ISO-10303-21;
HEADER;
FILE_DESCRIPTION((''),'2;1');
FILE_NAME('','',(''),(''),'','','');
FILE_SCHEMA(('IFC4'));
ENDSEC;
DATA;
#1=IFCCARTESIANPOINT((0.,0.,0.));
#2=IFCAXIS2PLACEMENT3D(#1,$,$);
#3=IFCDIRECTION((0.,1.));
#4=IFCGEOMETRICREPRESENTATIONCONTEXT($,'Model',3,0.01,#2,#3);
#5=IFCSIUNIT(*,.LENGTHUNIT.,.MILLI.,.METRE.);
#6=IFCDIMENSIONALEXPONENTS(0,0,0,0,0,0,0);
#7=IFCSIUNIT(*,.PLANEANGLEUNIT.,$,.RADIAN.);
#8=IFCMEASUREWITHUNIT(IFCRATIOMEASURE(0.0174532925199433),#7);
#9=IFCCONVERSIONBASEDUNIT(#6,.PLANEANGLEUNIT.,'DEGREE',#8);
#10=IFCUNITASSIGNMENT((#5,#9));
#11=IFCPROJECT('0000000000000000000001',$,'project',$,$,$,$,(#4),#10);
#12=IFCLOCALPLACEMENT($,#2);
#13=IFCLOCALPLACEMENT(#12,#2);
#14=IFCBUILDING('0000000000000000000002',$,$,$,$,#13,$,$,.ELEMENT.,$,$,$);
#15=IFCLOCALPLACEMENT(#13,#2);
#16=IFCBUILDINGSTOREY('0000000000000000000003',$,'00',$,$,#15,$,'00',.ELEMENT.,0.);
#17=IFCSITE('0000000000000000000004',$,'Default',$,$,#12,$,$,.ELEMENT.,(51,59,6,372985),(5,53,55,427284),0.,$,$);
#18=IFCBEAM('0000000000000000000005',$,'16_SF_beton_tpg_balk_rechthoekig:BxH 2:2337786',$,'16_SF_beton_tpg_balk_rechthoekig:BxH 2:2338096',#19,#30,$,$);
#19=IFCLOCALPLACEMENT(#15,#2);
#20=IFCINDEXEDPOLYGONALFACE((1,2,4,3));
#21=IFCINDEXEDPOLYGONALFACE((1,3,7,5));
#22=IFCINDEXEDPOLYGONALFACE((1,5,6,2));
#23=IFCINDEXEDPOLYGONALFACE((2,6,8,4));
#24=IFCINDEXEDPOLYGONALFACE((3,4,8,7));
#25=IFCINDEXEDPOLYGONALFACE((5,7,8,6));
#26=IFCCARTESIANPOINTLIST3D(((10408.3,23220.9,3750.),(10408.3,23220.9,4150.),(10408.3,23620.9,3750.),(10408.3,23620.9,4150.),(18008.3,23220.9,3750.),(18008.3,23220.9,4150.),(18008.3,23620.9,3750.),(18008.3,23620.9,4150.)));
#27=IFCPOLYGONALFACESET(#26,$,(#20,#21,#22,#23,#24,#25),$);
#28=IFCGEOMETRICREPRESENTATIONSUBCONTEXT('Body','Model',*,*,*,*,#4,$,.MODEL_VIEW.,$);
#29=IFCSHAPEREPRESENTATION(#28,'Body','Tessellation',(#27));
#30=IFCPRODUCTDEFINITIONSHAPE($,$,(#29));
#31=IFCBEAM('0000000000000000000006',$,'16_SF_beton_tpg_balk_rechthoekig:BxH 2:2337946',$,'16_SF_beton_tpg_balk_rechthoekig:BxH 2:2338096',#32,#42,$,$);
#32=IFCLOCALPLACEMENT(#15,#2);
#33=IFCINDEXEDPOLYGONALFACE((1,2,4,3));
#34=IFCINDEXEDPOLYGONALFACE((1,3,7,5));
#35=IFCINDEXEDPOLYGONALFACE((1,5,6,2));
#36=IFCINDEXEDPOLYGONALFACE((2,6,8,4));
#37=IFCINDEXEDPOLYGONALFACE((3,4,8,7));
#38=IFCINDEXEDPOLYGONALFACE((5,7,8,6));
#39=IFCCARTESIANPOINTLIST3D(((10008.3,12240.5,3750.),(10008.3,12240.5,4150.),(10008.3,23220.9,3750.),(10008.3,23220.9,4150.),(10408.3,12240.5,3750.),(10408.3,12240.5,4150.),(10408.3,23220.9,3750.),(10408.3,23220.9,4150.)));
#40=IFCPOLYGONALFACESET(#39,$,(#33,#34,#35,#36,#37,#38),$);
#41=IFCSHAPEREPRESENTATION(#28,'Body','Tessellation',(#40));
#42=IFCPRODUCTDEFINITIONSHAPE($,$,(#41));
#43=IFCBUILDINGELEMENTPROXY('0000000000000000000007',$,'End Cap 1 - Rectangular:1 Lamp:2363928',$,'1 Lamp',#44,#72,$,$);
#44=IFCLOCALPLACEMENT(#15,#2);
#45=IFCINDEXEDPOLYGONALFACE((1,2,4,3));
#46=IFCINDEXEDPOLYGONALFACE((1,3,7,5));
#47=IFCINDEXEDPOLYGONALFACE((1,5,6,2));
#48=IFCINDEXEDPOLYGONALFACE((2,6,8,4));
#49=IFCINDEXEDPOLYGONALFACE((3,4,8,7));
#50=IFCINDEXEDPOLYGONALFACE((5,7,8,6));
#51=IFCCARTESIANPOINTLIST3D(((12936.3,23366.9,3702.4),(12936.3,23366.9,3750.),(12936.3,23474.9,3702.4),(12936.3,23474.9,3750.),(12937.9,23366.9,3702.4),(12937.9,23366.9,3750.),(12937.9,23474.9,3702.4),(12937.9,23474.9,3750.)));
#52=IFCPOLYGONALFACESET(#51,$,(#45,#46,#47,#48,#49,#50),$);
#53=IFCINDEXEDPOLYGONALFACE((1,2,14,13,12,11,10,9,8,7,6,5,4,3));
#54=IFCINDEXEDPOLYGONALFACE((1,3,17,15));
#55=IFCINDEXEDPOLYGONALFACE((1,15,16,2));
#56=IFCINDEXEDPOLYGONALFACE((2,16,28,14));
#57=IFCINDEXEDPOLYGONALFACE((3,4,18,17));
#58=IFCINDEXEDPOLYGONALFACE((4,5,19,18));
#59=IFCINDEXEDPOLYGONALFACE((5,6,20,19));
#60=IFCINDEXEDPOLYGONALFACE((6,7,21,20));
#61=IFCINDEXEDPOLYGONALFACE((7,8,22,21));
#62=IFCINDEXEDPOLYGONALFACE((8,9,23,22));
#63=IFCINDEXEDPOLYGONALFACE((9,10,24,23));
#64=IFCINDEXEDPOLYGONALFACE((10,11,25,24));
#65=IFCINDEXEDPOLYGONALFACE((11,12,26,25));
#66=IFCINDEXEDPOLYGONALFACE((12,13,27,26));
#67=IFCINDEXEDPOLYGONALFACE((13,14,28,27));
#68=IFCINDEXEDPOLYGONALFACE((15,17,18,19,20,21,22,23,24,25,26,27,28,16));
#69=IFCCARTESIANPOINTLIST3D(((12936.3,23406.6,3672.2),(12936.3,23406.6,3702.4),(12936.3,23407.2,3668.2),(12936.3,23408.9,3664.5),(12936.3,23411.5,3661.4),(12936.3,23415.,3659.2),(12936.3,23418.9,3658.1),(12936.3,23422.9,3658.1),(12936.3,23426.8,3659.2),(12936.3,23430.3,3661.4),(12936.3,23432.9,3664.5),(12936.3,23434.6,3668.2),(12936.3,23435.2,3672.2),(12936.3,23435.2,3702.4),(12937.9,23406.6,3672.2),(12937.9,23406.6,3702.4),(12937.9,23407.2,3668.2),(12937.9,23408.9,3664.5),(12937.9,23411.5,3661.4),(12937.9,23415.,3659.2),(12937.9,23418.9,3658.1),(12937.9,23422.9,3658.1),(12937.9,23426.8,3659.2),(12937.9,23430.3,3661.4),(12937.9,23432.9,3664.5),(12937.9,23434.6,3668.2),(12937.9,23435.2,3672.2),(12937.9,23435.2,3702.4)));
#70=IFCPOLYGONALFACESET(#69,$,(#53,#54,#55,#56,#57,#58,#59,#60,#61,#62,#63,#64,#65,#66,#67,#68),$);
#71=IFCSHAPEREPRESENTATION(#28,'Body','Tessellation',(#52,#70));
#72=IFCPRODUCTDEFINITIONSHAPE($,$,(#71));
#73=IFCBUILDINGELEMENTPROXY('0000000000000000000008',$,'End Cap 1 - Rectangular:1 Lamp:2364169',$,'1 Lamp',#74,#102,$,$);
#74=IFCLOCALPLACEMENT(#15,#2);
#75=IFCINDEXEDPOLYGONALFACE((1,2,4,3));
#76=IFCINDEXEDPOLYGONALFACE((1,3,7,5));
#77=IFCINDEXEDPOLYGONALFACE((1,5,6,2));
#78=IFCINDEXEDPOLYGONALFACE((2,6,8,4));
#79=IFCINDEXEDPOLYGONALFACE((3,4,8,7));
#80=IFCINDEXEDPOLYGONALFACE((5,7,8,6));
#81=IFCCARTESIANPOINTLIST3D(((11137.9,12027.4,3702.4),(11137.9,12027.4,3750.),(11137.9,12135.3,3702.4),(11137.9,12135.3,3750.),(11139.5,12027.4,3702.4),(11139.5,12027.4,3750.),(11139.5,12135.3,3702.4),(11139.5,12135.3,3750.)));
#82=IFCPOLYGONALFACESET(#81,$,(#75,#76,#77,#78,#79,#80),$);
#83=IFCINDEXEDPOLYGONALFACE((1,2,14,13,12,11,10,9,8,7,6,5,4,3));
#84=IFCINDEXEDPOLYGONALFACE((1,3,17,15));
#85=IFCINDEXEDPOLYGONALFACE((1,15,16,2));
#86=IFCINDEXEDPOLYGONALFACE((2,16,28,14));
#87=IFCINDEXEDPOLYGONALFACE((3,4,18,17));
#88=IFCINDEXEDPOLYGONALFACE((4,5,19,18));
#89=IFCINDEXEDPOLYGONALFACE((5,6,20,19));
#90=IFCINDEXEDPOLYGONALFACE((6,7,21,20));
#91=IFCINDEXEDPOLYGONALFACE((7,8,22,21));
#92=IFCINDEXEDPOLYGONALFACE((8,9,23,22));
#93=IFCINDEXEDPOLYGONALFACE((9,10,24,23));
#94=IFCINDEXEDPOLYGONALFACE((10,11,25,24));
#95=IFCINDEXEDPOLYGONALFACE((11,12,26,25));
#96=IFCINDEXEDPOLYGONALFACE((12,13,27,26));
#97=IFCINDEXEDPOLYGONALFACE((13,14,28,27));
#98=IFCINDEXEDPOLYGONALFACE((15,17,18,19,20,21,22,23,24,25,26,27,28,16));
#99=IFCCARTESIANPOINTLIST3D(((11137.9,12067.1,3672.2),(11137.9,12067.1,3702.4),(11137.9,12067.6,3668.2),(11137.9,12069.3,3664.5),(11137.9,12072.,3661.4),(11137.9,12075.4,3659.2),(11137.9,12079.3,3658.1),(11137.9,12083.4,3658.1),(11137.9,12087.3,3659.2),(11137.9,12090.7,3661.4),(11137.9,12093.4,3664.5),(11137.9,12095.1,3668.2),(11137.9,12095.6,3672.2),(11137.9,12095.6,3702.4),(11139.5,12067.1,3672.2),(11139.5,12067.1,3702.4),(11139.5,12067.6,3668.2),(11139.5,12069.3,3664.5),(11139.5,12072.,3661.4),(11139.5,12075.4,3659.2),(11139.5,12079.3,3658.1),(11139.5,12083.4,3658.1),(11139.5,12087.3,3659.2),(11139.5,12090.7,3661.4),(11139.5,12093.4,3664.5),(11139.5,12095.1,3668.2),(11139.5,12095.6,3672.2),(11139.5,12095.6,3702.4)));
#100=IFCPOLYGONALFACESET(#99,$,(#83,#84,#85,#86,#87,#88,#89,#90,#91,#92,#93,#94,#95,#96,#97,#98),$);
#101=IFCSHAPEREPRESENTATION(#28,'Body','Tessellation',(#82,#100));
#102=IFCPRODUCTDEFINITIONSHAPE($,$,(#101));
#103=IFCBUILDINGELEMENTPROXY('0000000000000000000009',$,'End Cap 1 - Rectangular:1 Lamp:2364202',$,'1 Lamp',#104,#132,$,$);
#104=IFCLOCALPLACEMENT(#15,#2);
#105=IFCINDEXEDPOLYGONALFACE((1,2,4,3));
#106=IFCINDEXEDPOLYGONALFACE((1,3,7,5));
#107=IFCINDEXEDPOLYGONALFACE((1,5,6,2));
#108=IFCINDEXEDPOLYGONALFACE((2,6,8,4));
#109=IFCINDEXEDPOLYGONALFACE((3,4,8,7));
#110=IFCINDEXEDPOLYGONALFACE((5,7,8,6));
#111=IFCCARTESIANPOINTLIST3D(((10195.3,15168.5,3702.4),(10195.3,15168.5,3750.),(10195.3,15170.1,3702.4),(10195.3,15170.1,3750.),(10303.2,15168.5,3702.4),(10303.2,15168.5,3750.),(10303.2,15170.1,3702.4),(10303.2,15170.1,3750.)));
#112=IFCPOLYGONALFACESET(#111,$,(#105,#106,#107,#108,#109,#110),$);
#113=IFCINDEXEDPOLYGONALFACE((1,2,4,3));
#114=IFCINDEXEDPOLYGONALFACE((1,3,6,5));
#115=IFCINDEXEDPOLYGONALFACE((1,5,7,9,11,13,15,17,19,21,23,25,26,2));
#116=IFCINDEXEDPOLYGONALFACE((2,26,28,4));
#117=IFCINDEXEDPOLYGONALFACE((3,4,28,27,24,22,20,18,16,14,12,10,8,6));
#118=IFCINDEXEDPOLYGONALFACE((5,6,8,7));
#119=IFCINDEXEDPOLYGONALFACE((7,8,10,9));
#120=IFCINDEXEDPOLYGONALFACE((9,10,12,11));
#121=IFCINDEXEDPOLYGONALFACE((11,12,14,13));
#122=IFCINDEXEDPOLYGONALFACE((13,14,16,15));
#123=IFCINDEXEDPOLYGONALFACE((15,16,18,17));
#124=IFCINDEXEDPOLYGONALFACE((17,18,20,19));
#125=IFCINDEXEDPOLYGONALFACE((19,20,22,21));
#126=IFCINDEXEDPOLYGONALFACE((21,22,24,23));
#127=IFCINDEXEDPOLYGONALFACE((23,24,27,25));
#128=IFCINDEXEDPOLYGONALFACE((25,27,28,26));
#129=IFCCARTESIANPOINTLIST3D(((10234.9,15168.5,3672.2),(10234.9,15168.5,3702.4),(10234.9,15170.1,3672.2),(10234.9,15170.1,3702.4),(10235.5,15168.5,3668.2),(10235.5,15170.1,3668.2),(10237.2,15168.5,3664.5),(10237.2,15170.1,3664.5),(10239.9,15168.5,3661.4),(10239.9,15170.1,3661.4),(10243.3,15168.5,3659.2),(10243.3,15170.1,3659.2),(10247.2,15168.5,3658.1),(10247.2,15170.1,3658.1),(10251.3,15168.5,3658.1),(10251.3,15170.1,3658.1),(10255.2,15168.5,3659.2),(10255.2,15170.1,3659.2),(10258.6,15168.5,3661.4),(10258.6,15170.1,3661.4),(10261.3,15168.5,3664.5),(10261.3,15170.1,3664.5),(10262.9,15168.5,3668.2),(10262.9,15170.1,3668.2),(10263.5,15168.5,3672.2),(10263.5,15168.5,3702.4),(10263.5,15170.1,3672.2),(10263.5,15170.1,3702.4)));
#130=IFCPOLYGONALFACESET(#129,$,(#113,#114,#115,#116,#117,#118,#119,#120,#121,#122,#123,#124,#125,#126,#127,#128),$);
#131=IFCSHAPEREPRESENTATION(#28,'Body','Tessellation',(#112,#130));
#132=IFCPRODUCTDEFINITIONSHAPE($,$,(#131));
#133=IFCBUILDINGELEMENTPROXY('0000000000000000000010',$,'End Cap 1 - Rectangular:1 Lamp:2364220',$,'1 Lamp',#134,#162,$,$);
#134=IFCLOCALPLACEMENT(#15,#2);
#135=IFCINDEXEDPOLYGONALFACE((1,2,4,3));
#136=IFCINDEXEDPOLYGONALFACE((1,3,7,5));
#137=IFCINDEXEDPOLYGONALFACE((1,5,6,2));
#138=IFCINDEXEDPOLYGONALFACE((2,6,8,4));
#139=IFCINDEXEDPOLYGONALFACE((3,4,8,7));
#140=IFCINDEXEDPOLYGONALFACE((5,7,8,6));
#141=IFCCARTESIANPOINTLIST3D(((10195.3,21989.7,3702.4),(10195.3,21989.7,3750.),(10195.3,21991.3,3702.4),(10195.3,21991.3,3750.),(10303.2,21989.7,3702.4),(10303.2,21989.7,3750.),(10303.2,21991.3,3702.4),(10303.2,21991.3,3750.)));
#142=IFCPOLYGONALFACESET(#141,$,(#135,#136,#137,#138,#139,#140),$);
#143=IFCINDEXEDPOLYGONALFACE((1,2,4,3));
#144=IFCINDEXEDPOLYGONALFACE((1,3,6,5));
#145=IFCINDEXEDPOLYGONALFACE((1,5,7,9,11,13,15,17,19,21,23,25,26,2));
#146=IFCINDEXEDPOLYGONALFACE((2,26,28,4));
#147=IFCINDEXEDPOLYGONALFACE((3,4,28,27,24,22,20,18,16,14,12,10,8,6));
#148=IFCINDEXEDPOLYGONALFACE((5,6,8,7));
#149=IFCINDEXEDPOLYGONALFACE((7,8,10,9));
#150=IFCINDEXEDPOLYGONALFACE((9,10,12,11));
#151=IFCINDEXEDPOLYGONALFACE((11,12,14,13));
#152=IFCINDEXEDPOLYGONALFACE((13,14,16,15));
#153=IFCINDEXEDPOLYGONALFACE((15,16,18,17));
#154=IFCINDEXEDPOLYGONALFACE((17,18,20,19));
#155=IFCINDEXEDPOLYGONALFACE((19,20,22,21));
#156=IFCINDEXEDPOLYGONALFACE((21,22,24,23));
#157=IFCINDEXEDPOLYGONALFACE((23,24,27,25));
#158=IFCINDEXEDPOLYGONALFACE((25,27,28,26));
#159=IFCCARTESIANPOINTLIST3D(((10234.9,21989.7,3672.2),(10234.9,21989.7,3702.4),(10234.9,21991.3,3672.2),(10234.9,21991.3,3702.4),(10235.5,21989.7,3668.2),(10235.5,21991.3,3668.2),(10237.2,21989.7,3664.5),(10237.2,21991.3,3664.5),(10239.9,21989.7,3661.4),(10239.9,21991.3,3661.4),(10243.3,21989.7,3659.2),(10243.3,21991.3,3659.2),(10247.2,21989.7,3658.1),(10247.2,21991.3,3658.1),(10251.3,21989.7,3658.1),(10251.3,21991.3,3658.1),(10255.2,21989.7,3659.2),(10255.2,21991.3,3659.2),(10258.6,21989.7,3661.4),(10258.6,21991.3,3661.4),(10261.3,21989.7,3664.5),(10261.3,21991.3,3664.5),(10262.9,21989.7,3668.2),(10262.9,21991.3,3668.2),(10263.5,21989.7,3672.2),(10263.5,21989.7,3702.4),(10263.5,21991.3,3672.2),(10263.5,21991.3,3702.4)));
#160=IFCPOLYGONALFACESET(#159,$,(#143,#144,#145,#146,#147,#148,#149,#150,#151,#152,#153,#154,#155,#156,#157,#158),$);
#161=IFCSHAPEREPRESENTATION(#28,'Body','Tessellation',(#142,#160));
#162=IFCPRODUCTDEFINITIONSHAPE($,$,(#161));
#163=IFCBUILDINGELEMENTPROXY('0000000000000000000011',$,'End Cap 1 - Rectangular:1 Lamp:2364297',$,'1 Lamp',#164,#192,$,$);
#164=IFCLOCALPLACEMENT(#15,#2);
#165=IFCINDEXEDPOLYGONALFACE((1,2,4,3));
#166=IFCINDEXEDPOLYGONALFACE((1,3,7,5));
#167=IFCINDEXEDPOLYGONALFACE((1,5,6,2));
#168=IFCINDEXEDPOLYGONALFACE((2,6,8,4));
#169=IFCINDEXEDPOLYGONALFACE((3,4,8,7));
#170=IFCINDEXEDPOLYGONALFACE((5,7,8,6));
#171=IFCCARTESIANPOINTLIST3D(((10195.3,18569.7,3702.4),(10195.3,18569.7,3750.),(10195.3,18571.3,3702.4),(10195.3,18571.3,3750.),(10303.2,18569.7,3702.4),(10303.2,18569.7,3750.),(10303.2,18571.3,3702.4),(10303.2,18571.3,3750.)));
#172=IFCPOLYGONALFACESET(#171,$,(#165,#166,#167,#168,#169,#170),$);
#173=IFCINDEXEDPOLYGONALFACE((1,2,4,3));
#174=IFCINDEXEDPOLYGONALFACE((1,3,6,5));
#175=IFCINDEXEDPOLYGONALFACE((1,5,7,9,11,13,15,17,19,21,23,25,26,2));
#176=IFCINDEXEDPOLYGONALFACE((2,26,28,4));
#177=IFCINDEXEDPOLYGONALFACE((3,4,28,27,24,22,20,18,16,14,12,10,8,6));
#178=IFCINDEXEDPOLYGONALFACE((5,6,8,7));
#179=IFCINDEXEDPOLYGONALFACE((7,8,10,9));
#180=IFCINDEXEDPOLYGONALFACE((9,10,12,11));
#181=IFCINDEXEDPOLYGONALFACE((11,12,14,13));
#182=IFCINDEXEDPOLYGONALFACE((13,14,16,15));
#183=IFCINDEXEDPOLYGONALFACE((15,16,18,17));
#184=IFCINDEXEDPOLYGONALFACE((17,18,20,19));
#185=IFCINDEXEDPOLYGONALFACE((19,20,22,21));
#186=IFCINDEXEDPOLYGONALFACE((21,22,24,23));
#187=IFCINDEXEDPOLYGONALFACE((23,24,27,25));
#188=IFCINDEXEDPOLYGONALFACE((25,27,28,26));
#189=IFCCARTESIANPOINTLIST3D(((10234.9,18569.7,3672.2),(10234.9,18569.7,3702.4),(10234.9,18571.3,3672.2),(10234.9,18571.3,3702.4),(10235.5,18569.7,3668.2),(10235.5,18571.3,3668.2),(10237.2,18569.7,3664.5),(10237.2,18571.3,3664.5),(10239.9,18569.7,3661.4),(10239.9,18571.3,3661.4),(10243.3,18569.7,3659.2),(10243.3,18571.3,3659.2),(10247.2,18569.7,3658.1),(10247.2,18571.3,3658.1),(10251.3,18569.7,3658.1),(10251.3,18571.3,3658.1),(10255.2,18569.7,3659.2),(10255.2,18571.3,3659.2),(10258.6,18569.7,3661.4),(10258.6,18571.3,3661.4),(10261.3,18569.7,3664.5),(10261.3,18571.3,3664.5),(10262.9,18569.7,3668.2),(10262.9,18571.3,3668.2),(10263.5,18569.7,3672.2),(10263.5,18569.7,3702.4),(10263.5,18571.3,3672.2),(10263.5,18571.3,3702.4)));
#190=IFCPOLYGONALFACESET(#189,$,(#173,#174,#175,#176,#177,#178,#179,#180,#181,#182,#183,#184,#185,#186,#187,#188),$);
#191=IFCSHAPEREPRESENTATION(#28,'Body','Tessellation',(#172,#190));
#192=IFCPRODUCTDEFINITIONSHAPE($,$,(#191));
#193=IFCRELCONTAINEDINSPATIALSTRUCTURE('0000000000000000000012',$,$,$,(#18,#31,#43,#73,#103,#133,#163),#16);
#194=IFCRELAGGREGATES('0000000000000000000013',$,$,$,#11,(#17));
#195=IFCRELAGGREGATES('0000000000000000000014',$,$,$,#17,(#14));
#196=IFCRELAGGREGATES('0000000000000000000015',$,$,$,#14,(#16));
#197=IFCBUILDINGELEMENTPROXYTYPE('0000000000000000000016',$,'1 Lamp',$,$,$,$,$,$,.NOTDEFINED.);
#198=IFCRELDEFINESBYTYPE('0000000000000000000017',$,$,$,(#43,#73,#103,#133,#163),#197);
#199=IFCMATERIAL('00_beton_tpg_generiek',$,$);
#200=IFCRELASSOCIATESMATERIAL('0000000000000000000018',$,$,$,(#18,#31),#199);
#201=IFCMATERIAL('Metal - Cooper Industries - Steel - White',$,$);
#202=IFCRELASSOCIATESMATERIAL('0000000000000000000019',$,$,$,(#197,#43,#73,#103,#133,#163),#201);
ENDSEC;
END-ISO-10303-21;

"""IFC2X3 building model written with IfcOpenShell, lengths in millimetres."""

from ifc_helpers import new_model, entity, si_unit, converted_unit, direction, frame, frame_2d, origin, origin_2d_with_axis, place, context, subcontext, project, spatial, polyline, circle_curve, parameter, trimmed, segment, composite_curve, rectangle, outline, extrude, source, transform, mapped, material, type_object, type_shapes, element, save


model = new_model("IFC2X3")

# Units and contexts
model_context = context("Model", 3, precision=0.01, world=origin(), true_north=direction((0.0, 1.0)))
body_context = subcontext(model_context, "Body", "Model", "MODEL_VIEW")
ifc_project = project(units=[si_unit("LENGTHUNIT", "METRE", prefix="MILLI"), converted_unit("PLANEANGLEUNIT", "DEGREE", entity("IfcRatioMeasure", 0.0174532925199433), si_unit("PLANEANGLEUNIT", "RADIAN"), dimensions=[0, 0, 0, 0, 0, 0, 0])], contexts=[model_context])

# Site, building, storey
site_placement = place(None, origin())
site = spatial("IfcSite", under=ifc_project, at=site_placement, Name="Default", CompositionType="ELEMENT", RefLatitude=(51, 59, 6, 372985), RefLongitude=(5, 53, 55, 427284), RefElevation=0.0)
building_placement = place(site_placement, origin())
building = spatial("IfcBuilding", under=site, at=building_placement, CompositionType="ELEMENT")
storey_placement = place(building_placement, origin())
storey = spatial("IfcBuildingStorey", under=building, at=storey_placement, Name="00", LongName="00", CompositionType="ELEMENT", Elevation=0.0)

# Beams
ifc_material_1 = material(Name="00_beton_tpg_generiek")
beam_1_placement = place(storey_placement, frame((10408.3, 23420.9, 4150.0)))
element("IfcBeam", 1, at=beam_1_placement, inside=storey, material=ifc_material_1, Name="16_SF_beton_tpg_balk_rechthoekig:BxH 2:2337786", ObjectType="16_SF_beton_tpg_balk_rechthoekig:BxH 2:2338096", context=body_context, shape_type="SweptSolid", body=[
    extrude(rectangle(XDim=400.0, YDim=400.0, at=frame_2d((0.0, 0.0), x_axis=(1.0, 0.0))), frame((0.0, 0.0, -200.0), z_axis=(1.0, 0.0, 0.0), x_axis=(0.0, 0.0, -1.0)), (0.0, 0.0, 1.0), 7600.0),
])
beam_2_placement = place(storey_placement, frame((10208.3, 23220.9, 4150.0), z_axis=(0.0, 0.0, 1.0), x_axis=(0.0, -1.0, 0.0)))
element("IfcBeam", 2, at=beam_2_placement, inside=storey, material=ifc_material_1, Name="16_SF_beton_tpg_balk_rechthoekig:BxH 2:2337946", ObjectType="16_SF_beton_tpg_balk_rechthoekig:BxH 2:2338096", context=body_context, shape_type="SweptSolid", body=[
    extrude(rectangle(XDim=400.0, YDim=400.0, at=frame_2d((0.0, 0.0), x_axis=(1.0, 0.0))), frame((0.0, 0.0, -200.0), z_axis=(1.0, 0.0, 0.0), x_axis=(0.0, 0.0, -1.0)), (0.0, 0.0, 1.0), 10980.5),
])

# Building element proxies
ifc_material_2 = material(Name="Metal - Cooper Industries - Steel - White")
building_element_proxy_type_1 = type_object("IfcBuildingElementProxyType", Name="1 Lamp", PredefinedType="NOTDEFINED", material=ifc_material_2)
shared_shape_1 = source(origin(), body_context, "Body", "SweptSolid", [
    extrude(rectangle(XDim=1.6, YDim=108.0, at=origin_2d_with_axis()), frame((0.0, 0.0, 0.0), z_axis=(0.0, 0.0, 1.0), x_axis=(0.0, 1.0, 0.0)), (0.0, 0.0, 1.0), 47.6),
    extrude(outline(composite_curve([segment(polyline([(-15.1, -14.3), (15.1, -14.3)]), True, "CONTINUOUS"), segment(polyline([(15.1, -14.3), (15.1, 14.3)]), True, "CONTINUOUS"), segment(polyline([(15.1, 14.3), (-15.1, 14.3)]), True, "CONTINUOUS"), segment(trimmed(circle_curve(frame_2d((-15.1, 0.0), x_axis=(0.0, -1.0)), 14.3), [parameter(180.0)], [parameter(0.0)], True, "PARAMETER"), True, "CONTINUOUS")], self_intersect=False)), frame((0.0, -0.8, 62.7), z_axis=(0.0, 1.0, 0.0), x_axis=(0.0, 0.0, -1.0)), (0.0, 0.0, 1.0), 1.6),
])
type_shapes(building_element_proxy_type_1, [shared_shape_1])
for number, where, z_axis, x_axis, name in (
    (3, (12937.1, 23420.9, 3750.0), (0.0, 0.0, -1.0), (0.0, -1.0, 0.0), "End Cap 1 - Rectangular:1 Lamp:2363928"),
    (4, (11138.7, 12081.4, 3750.0), (0.0, 0.0, -1.0), (0.0, 1.0, 0.0), "End Cap 1 - Rectangular:1 Lamp:2364169"),
    (5, (10249.2, 15169.3, 3750.0), (0.0, 0.0, -1.0), (1.0, 0.0, 0.0), "End Cap 1 - Rectangular:1 Lamp:2364202"),
    (6, (10249.2, 21990.5, 3750.0), (0.0, 0.0, -1.0), (1.0, 0.0, 0.0), "End Cap 1 - Rectangular:1 Lamp:2364220"),
    (7, (10249.2, 18570.5, 3750.0), (0.0, 0.0, -1.0), (1.0, 0.0, 0.0), "End Cap 1 - Rectangular:1 Lamp:2364297"),
):
    element("IfcBuildingElementProxy", number, at=place(storey_placement, frame(where, z_axis=z_axis, x_axis=x_axis)), inside=storey, type_object=building_element_proxy_type_1, material=ifc_material_2, Name=name, ObjectType="1 Lamp", context=body_context, shape_type="MappedRepresentation", body=[
        mapped(shared_shape_1, transform((0.0, 0.0, 0.0), scale=1.0)),
    ])

save(model, "model.ifc")
